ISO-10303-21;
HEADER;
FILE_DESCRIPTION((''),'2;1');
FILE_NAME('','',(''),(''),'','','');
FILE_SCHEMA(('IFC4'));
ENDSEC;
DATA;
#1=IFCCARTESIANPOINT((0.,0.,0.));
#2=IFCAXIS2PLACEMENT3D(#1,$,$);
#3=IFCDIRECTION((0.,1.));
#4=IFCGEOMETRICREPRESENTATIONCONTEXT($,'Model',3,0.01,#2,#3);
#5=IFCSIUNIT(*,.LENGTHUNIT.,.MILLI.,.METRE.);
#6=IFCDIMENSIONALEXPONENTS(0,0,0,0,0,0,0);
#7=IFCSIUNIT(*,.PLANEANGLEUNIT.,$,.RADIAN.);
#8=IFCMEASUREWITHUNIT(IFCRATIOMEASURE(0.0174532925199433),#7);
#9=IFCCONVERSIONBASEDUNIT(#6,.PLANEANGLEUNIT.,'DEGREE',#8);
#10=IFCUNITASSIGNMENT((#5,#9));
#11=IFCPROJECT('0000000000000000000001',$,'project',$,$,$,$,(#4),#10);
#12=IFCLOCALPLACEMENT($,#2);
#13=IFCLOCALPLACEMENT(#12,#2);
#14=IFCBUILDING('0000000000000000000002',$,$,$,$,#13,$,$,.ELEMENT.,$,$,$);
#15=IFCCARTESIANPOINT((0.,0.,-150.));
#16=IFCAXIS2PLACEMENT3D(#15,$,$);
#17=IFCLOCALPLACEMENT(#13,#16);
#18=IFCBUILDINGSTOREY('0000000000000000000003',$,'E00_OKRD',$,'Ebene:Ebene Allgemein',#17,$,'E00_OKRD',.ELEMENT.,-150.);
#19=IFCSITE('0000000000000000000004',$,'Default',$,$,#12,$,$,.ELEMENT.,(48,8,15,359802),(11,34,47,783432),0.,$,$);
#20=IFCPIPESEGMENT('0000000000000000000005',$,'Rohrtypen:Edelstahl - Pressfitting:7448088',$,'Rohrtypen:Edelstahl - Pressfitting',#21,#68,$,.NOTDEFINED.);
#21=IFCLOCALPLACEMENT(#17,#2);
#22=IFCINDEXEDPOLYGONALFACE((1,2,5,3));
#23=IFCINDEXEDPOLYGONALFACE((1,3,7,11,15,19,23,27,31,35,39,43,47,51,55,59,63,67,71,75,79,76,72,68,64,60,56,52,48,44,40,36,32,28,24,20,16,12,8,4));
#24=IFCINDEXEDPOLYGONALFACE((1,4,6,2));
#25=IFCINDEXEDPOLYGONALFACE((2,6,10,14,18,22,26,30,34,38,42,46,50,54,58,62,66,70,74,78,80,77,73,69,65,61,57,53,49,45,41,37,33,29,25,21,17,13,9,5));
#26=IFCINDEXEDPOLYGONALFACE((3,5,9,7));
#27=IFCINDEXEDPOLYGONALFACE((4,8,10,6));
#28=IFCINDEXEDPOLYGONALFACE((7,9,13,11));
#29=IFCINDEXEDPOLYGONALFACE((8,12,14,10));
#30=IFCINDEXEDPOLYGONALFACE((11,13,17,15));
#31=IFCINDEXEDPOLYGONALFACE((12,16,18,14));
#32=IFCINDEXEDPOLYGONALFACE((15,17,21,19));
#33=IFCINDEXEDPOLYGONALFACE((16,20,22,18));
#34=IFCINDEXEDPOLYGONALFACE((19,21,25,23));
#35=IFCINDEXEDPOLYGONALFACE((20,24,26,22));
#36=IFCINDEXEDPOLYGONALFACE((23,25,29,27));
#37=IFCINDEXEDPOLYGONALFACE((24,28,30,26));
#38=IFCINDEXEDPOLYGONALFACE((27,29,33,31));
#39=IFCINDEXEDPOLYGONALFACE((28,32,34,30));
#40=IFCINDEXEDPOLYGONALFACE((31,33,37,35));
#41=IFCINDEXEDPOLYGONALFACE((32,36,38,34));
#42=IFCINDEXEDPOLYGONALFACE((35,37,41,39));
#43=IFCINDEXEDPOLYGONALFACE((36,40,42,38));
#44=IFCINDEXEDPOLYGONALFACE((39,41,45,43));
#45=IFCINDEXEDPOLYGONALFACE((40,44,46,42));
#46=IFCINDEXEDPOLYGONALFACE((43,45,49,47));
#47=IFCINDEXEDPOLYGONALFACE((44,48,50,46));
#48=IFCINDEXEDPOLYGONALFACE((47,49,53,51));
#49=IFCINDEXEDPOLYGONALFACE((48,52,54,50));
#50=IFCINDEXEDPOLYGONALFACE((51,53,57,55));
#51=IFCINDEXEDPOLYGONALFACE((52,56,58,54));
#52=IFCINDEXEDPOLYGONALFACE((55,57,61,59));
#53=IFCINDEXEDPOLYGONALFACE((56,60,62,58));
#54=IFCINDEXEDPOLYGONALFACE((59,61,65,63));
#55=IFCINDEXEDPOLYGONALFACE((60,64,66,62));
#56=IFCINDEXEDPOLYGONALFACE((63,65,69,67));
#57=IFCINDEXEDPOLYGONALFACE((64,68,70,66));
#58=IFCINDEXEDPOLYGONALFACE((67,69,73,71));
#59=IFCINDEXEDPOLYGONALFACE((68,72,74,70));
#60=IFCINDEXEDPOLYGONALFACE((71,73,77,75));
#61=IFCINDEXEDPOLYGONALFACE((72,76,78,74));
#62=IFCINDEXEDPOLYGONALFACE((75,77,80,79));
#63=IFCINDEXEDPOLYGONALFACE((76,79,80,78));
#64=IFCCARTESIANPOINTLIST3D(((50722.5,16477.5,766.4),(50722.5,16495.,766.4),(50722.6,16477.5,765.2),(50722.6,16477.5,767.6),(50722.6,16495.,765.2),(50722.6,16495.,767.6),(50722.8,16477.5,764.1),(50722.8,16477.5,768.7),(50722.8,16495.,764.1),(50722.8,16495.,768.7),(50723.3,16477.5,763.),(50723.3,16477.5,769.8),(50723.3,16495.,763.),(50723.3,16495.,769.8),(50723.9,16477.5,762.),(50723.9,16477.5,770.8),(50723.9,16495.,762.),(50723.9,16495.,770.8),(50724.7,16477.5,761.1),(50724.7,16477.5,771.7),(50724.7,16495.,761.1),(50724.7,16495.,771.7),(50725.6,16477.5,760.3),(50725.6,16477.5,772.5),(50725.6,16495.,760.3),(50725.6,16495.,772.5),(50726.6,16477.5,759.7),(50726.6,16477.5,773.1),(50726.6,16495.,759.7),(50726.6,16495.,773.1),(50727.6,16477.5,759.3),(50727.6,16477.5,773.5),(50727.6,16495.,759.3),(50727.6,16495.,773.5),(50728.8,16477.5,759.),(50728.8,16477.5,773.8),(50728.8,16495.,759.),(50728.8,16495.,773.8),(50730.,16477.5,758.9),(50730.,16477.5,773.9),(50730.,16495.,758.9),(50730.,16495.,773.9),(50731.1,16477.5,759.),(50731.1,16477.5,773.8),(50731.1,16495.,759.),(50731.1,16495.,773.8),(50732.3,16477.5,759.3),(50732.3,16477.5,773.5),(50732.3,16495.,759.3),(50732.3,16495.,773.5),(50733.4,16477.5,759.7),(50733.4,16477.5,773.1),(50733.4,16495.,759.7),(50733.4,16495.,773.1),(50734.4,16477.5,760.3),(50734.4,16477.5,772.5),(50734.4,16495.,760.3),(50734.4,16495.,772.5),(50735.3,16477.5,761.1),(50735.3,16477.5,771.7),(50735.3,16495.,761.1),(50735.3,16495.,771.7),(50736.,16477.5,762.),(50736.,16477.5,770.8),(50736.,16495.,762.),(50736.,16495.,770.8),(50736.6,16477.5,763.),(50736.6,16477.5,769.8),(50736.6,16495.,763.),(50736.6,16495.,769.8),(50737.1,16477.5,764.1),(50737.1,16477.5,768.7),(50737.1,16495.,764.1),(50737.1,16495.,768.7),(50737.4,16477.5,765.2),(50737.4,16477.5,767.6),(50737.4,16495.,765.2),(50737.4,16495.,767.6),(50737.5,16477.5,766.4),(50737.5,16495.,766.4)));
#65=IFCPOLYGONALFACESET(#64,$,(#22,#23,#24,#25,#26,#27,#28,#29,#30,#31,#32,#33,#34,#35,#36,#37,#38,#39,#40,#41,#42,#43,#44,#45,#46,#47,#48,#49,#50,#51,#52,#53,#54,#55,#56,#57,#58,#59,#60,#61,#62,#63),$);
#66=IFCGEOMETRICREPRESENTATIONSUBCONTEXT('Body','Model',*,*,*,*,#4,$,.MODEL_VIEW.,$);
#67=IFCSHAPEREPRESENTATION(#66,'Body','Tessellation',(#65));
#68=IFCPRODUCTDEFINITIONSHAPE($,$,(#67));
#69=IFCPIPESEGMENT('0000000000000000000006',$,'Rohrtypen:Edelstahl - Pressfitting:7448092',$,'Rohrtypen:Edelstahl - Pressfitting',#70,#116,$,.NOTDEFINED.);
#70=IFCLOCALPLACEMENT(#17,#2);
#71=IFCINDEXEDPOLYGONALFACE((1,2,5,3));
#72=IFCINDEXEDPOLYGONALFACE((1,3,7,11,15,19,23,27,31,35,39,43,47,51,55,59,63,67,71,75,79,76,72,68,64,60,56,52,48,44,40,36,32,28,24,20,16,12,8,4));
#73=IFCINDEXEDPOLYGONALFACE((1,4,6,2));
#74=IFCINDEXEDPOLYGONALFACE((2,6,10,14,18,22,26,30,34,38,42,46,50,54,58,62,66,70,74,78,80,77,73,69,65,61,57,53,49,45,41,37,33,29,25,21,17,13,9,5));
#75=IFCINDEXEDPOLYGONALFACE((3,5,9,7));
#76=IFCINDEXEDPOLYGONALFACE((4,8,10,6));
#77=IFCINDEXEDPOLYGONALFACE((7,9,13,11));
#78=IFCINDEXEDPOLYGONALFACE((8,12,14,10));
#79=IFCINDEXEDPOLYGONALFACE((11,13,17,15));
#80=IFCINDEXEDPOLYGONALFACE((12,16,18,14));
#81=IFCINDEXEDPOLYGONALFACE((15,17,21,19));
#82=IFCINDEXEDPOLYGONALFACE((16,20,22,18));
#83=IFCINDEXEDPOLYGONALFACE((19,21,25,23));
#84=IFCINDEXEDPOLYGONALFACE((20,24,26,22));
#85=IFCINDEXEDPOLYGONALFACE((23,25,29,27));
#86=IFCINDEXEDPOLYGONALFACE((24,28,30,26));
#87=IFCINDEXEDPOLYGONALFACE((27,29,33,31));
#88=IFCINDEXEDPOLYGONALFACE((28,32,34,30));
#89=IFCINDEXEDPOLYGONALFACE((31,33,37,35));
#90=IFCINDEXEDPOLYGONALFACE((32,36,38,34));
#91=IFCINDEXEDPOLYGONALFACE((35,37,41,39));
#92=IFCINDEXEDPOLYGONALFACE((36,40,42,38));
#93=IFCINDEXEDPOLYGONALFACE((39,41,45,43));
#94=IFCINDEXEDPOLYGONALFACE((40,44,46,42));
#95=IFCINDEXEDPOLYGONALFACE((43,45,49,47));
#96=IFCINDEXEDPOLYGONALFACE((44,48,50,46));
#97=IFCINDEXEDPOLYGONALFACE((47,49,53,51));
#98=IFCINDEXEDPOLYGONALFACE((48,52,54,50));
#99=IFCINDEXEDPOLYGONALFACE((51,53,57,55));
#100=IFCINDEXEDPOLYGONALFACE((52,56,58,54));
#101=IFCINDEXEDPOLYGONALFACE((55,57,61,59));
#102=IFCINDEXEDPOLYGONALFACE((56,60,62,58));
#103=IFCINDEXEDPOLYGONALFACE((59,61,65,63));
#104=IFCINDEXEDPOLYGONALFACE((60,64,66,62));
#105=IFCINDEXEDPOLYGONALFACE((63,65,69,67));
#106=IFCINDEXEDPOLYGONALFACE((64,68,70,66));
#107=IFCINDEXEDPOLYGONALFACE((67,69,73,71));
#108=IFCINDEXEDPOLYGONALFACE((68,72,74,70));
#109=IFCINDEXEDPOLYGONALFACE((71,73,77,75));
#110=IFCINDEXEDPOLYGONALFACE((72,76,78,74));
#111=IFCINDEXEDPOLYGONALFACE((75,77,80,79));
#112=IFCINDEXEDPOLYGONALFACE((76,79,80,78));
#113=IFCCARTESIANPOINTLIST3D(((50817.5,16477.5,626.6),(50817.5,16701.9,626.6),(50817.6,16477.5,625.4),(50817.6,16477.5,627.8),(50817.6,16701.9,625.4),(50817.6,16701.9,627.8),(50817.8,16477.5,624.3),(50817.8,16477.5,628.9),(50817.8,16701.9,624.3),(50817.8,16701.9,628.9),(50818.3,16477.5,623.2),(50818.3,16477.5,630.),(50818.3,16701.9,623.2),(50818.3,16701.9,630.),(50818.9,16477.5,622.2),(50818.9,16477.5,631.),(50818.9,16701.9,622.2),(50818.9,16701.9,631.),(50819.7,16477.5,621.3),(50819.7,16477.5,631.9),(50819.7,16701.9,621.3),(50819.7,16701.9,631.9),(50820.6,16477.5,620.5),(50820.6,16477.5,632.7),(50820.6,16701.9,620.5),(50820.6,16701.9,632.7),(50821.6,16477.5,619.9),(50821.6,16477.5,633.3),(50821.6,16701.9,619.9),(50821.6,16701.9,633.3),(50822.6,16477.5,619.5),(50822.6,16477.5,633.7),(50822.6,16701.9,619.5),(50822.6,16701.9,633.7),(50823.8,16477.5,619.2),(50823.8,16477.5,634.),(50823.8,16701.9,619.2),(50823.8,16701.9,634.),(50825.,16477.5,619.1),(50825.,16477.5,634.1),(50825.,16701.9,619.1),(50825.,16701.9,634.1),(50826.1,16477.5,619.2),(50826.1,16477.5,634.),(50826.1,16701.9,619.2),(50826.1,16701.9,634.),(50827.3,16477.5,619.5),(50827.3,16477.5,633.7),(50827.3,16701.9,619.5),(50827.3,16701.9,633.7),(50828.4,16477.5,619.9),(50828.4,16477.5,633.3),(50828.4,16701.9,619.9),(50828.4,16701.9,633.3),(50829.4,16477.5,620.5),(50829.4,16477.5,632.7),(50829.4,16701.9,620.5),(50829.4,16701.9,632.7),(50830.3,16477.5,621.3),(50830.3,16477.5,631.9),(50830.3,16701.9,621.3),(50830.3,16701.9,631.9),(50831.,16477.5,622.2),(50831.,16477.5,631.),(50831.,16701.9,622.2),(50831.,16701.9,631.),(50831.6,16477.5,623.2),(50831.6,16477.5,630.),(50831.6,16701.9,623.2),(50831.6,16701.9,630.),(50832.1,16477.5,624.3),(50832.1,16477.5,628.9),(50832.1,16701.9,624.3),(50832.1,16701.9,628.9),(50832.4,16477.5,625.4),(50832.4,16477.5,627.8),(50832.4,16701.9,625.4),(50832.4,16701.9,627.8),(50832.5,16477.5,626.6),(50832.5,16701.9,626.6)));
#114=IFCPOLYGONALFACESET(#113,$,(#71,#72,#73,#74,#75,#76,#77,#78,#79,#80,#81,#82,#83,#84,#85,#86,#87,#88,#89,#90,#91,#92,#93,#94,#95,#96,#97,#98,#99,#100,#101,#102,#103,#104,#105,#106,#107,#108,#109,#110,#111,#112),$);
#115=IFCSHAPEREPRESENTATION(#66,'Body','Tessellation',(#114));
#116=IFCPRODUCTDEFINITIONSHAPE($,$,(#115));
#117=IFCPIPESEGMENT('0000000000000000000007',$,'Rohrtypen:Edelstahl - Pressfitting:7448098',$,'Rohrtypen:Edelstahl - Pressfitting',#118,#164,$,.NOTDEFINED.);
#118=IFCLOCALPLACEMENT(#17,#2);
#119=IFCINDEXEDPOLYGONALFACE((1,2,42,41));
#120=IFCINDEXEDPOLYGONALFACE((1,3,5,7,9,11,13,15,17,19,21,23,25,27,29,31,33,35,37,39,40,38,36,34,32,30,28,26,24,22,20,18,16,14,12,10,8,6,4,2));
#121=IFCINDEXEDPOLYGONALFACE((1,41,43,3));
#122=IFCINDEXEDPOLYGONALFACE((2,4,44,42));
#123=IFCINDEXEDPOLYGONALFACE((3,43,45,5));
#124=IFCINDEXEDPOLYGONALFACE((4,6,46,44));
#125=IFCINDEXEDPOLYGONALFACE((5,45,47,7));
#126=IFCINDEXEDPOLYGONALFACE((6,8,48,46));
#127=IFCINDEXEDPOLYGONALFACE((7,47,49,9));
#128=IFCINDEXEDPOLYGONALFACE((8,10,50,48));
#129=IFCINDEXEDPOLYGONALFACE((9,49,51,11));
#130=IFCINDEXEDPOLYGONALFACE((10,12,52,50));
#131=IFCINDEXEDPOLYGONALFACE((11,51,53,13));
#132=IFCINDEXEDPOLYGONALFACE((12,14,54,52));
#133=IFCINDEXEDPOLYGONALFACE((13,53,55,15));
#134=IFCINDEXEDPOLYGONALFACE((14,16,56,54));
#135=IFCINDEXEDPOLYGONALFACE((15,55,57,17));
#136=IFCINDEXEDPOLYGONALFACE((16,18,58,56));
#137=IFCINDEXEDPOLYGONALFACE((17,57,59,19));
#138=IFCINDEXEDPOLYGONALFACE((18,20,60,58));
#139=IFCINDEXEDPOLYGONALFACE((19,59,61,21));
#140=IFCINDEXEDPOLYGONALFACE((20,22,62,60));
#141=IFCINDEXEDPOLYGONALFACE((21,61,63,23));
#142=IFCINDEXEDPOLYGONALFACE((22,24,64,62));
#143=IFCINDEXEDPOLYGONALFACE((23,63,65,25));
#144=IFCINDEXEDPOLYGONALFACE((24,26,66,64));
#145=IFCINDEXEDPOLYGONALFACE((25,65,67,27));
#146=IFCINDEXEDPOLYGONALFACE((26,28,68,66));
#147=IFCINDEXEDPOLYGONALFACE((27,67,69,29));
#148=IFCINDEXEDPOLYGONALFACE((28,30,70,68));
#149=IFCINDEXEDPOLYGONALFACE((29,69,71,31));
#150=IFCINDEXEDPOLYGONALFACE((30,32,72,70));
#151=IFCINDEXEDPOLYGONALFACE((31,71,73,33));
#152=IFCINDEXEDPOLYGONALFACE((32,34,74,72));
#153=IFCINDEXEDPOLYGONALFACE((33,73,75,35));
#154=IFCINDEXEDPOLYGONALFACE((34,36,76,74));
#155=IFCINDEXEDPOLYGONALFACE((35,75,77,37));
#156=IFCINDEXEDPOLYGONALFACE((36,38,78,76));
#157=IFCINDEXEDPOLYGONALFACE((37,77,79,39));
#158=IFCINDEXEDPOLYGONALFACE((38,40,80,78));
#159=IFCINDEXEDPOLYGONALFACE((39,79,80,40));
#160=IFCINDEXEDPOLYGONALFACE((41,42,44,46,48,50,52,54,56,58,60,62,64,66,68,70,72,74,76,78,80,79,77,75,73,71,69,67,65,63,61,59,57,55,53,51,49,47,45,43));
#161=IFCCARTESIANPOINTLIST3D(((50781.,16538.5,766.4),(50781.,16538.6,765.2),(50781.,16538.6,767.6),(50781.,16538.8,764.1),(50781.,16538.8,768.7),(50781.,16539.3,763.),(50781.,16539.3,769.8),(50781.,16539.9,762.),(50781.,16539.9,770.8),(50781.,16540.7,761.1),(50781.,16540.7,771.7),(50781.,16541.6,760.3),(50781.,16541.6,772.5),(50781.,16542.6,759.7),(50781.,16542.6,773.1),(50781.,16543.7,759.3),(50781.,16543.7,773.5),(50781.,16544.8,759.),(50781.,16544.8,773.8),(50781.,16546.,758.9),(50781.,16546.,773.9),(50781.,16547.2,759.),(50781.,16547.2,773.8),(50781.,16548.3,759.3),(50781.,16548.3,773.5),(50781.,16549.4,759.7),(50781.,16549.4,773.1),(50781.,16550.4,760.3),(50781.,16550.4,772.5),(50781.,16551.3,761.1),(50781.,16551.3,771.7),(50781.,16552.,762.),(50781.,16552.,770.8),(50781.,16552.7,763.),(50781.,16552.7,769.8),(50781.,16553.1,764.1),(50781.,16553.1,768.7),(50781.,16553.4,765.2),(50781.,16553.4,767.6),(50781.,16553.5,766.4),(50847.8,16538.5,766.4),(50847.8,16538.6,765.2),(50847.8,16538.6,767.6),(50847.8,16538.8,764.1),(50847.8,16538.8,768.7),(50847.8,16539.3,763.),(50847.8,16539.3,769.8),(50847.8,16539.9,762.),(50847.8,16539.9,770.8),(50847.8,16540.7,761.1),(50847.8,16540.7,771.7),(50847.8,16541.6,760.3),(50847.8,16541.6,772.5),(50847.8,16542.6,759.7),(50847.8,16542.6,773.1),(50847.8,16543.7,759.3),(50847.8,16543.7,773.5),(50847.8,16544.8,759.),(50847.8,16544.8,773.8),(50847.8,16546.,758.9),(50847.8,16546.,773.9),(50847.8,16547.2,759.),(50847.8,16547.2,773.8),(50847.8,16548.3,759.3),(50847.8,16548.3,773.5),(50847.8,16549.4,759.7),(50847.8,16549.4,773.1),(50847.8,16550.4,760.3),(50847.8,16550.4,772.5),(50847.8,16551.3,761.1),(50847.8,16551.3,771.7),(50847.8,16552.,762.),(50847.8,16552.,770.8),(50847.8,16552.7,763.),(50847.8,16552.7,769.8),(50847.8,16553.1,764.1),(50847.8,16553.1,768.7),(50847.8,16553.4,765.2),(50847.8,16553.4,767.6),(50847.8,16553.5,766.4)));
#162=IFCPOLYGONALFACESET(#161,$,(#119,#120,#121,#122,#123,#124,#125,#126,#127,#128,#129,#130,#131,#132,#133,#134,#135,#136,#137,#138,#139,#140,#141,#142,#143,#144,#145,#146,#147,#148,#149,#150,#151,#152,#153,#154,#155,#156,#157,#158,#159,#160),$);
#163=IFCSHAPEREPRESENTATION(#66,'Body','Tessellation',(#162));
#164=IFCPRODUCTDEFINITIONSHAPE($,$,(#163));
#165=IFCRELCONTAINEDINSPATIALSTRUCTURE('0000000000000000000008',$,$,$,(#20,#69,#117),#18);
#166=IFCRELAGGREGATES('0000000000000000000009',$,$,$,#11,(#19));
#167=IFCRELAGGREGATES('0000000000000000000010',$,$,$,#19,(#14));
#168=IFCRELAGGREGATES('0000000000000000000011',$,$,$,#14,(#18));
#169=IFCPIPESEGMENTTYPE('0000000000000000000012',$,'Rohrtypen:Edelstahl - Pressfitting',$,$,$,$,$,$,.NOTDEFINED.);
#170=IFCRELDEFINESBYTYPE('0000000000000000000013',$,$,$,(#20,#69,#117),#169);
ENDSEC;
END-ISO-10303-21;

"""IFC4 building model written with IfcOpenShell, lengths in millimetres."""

from ifc_helpers import new_model, entity, si_unit, converted_unit, direction, frame, origin, place, context, subcontext, project, spatial, indexed_curve, outline, extrude, type_object, element, save


model = new_model("IFC4")

# Units and contexts
model_context = context("Model", 3, precision=0.01, world=origin(), true_north=direction((0.0, 1.0)))
body_context = subcontext(model_context, "Body", "Model", "MODEL_VIEW")
ifc_project = project(units=[si_unit("LENGTHUNIT", "METRE", prefix="MILLI"), converted_unit("PLANEANGLEUNIT", "DEGREE", entity("IfcRatioMeasure", 0.0174532925199433), si_unit("PLANEANGLEUNIT", "RADIAN"), dimensions=[0, 0, 0, 0, 0, 0, 0])], contexts=[model_context])

# Site, building, storey
site_placement = place(None, origin())
site = spatial("IfcSite", under=ifc_project, at=site_placement, Name="Default", CompositionType="ELEMENT", RefLatitude=(48, 8, 15, 359802), RefLongitude=(11, 34, 47, 783432), RefElevation=0.0)
building_placement = place(site_placement, origin())
building = spatial("IfcBuilding", under=site, at=building_placement, CompositionType="ELEMENT")
storey_placement = place(building_placement, frame((0.0, 0.0, -150.0)))
storey = spatial("IfcBuildingStorey", under=building, at=storey_placement, Name="E00_OKRD", ObjectType="Ebene:Ebene Allgemein", LongName="E00_OKRD", CompositionType="ELEMENT", Elevation=-150.0)

# Pipe segments
pipe_segment_type_1 = type_object("IfcPipeSegmentType", Name="Rohrtypen:Edelstahl - Pressfitting", PredefinedType="NOTDEFINED")
pipe_segment_1_placement = place(storey_placement, origin())
element("IfcPipeSegment", 1, at=pipe_segment_1_placement, inside=storey, type_object=pipe_segment_type_1, Name="Rohrtypen:Edelstahl - Pressfitting:7448088", ObjectType="Rohrtypen:Edelstahl - Pressfitting", PredefinedType="NOTDEFINED", context=body_context, shape_type="SweptSolid", body=[
    extrude(outline(indexed_curve([(7.5, 0.0), (7.4, 1.2), (7.1, 2.3), (6.7, 3.4), (6.1, 4.4), (5.3, 5.3), (4.4, 6.1), (3.4, 6.7), (2.3, 7.1), (1.2, 7.4), (0.0, 7.5), (-1.2, 7.4), (-2.3, 7.1), (-3.4, 6.7), (-4.4, 6.1), (-5.3, 5.3), (-6.1, 4.4), (-6.7, 3.4), (-7.1, 2.3), (-7.4, 1.2), (-7.5, 0.0), (-7.4, -1.2), (-7.1, -2.3), (-6.7, -3.4), (-6.1, -4.4), (-5.3, -5.3), (-4.4, -6.1), (-3.4, -6.7), (-2.3, -7.1), (-1.2, -7.4), (0.0, -7.5), (1.2, -7.4), (2.3, -7.1), (3.4, -6.7), (4.4, -6.1), (5.3, -5.3), (6.1, -4.4), (6.7, -3.4), (7.1, -2.3), (7.4, -1.2), (7.5, 0.0)], self_intersect=False)), frame((50730.0, 16477.5, 766.4), z_axis=(0.0, 1.0, 0.0), x_axis=(1.0, 0.0, 0.0)), (0.0, 0.0, 1.0), 17.4),
])
pipe_segment_2_placement = place(storey_placement, origin())
element("IfcPipeSegment", 2, at=pipe_segment_2_placement, inside=storey, type_object=pipe_segment_type_1, Name="Rohrtypen:Edelstahl - Pressfitting:7448092", ObjectType="Rohrtypen:Edelstahl - Pressfitting", PredefinedType="NOTDEFINED", context=body_context, shape_type="SweptSolid", body=[
    extrude(outline(indexed_curve([(7.5, 0.0), (7.4, 1.2), (7.1, 2.3), (6.7, 3.4), (6.1, 4.4), (5.3, 5.3), (4.4, 6.1), (3.4, 6.7), (2.3, 7.1), (1.2, 7.4), (0.0, 7.5), (-1.2, 7.4), (-2.3, 7.1), (-3.4, 6.7), (-4.4, 6.1), (-5.3, 5.3), (-6.1, 4.4), (-6.7, 3.4), (-7.1, 2.3), (-7.4, 1.2), (-7.5, 0.0), (-7.4, -1.2), (-7.1, -2.3), (-6.7, -3.4), (-6.1, -4.4), (-5.3, -5.3), (-4.4, -6.1), (-3.4, -6.7), (-2.3, -7.1), (-1.2, -7.4), (0.0, -7.5), (1.2, -7.4), (2.3, -7.1), (3.4, -6.7), (4.4, -6.1), (5.3, -5.3), (6.1, -4.4), (6.7, -3.4), (7.1, -2.3), (7.4, -1.2), (7.5, 0.0)], self_intersect=False)), frame((50825.0, 16477.5, 626.6), z_axis=(0.0, 1.0, 0.0), x_axis=(1.0, 0.0, 0.0)), (0.0, 0.0, 1.0), 224.3),
])
pipe_segment_3_placement = place(storey_placement, origin())
element("IfcPipeSegment", 3, at=pipe_segment_3_placement, inside=storey, type_object=pipe_segment_type_1, Name="Rohrtypen:Edelstahl - Pressfitting:7448098", ObjectType="Rohrtypen:Edelstahl - Pressfitting", PredefinedType="NOTDEFINED", context=body_context, shape_type="SweptSolid", body=[
    extrude(outline(indexed_curve([(7.5, 0.0), (7.4, 1.2), (7.1, 2.3), (6.7, 3.4), (6.1, 4.4), (5.3, 5.3), (4.4, 6.1), (3.4, 6.7), (2.3, 7.1), (1.2, 7.4), (0.0, 7.5), (-1.2, 7.4), (-2.3, 7.1), (-3.4, 6.7), (-4.4, 6.1), (-5.3, 5.3), (-6.1, 4.4), (-6.7, 3.4), (-7.1, 2.3), (-7.4, 1.2), (-7.5, 0.0), (-7.4, -1.2), (-7.1, -2.3), (-6.7, -3.4), (-6.1, -4.4), (-5.3, -5.3), (-4.4, -6.1), (-3.4, -6.7), (-2.3, -7.1), (-1.2, -7.4), (0.0, -7.5), (1.2, -7.4), (2.3, -7.1), (3.4, -6.7), (4.4, -6.1), (5.3, -5.3), (6.1, -4.4), (6.7, -3.4), (7.1, -2.3), (7.4, -1.2), (7.5, 0.0)], self_intersect=False)), frame((50781.0, 16546.0, 766.4), z_axis=(1.0, 0.0, 0.0), x_axis=(0.0, -1.0, 0.0)), (0.0, 0.0, 1.0), 66.8),
])

save(model, "model.ifc")
